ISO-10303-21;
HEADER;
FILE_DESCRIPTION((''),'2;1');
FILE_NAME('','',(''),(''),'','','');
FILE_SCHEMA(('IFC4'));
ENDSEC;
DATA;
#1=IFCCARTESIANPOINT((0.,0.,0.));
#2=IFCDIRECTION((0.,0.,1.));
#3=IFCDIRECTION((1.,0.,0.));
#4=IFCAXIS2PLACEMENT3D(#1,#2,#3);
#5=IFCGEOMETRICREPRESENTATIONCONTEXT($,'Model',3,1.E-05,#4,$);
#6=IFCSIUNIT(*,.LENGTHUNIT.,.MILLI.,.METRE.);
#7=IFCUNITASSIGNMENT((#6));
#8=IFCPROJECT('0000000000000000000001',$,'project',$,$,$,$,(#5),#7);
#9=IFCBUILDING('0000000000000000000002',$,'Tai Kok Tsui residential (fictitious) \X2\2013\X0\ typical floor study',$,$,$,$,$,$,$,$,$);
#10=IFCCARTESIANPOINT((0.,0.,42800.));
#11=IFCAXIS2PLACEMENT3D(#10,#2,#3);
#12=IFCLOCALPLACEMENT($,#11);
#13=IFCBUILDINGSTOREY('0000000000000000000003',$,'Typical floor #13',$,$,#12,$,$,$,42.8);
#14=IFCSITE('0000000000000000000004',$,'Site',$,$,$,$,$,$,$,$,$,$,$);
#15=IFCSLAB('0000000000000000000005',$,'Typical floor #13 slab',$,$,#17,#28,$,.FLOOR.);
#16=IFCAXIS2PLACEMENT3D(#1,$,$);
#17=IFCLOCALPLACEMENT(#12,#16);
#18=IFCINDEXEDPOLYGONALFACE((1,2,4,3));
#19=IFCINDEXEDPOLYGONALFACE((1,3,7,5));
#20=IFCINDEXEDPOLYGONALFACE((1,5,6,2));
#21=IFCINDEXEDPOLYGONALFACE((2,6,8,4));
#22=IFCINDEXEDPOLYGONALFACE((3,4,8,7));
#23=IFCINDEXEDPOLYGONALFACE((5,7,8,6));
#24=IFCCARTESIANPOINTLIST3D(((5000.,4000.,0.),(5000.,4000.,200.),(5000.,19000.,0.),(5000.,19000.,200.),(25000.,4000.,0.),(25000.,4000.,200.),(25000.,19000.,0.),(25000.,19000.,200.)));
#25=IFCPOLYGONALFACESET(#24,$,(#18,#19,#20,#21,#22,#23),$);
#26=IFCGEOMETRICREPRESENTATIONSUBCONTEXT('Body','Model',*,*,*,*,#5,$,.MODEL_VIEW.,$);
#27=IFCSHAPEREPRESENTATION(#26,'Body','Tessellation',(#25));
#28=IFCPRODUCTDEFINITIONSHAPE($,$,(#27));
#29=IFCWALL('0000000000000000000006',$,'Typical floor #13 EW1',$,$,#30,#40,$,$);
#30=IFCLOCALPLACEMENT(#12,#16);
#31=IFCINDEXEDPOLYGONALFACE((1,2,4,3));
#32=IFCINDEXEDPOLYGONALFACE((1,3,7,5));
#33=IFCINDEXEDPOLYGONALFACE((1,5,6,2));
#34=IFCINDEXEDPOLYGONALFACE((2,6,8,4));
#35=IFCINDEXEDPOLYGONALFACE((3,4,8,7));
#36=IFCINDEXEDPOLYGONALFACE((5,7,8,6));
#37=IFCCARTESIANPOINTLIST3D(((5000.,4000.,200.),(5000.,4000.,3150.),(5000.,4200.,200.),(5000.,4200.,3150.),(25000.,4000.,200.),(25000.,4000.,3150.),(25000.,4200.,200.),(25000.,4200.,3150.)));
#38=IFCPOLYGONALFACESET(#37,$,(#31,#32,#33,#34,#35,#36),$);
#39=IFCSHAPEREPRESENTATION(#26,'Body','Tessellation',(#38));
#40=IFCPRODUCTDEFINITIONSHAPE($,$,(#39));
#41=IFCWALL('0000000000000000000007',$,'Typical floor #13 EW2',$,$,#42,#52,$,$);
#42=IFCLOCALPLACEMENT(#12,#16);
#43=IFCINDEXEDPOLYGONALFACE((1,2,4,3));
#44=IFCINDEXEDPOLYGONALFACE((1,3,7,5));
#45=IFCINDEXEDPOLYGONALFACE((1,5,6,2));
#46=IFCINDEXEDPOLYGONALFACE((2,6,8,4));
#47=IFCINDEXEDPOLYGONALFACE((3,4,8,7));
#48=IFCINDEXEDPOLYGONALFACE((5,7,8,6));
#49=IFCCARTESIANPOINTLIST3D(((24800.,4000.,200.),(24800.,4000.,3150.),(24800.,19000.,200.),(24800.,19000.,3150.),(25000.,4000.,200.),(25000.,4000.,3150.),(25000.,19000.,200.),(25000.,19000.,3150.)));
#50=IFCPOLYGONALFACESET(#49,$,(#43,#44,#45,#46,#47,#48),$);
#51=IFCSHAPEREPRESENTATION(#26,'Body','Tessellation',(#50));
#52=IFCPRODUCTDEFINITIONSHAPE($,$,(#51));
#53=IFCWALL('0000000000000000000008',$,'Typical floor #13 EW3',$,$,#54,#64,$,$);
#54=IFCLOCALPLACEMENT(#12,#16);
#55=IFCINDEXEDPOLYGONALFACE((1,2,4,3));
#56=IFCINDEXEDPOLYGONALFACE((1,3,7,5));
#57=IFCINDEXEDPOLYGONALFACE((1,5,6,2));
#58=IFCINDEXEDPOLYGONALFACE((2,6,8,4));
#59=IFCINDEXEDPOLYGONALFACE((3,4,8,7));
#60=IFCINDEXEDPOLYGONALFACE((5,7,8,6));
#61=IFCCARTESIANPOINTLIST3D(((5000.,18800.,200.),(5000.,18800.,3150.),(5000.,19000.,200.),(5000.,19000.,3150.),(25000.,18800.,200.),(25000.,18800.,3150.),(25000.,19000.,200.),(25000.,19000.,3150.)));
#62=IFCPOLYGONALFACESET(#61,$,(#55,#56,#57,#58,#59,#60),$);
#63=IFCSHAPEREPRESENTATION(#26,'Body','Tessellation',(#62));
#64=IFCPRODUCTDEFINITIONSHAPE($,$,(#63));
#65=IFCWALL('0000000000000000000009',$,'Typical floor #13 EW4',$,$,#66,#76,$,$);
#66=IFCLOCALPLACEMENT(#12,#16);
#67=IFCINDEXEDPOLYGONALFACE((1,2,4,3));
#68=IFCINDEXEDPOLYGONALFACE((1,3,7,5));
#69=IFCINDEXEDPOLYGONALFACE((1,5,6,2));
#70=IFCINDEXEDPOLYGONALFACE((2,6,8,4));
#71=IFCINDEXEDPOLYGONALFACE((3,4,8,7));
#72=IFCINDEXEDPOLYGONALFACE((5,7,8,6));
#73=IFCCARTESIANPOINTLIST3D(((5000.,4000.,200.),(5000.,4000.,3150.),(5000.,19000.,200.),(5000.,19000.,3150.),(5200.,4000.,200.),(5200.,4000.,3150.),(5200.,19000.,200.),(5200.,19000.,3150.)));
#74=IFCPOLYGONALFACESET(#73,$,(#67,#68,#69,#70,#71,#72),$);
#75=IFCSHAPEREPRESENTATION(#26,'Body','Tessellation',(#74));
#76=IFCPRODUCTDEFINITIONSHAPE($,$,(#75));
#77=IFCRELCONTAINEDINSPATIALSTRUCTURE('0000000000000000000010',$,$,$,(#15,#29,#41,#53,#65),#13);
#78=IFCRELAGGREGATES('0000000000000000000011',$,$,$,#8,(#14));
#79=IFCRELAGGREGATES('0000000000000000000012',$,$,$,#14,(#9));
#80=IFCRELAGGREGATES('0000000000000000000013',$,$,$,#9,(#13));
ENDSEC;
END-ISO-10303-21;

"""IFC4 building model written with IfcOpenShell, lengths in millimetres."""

from ifc_helpers import new_model, si_unit, frame, origin_with_axes, place, context, subcontext, project, spatial, indexed_curve, outline, extrude, element, save


model = new_model("IFC4")

# Units and contexts
model_context = context("Model", 3, precision=1e-05, world=origin_with_axes())
body_context = subcontext(model_context, "Body", "Model", "MODEL_VIEW")
ifc_project = project(units=[si_unit("LENGTHUNIT", "METRE", prefix="MILLI")], contexts=[model_context])

# Site, building, storey
site = spatial("IfcSite", under=ifc_project, Name="Site")
building = spatial("IfcBuilding", under=site, Name="Tai Kok Tsui residential (fictitious) – typical floor study")
storey_placement = place(None, frame((0.0, 0.0, 42800.0), z_axis=(0.0, 0.0, 1.0), x_axis=(1.0, 0.0, 0.0)))
storey = spatial("IfcBuildingStorey", under=building, at=storey_placement, Name="Typical floor #13", Elevation=42.8)

# Slab
slab_placement = place(storey_placement, origin_with_axes())
element("IfcSlab", 1, at=slab_placement, inside=storey, Name="Typical floor #13 slab", PredefinedType="FLOOR", context=body_context, shape_type="SweptSolid", body=[
    extrude(outline(indexed_curve([(5000.0, 4000.0), (25000.0, 4000.0), (25000.0, 19000.0), (5000.0, 19000.0)])), None, (0.0, 0.0, 1.0), 200.0),
])

# Walls
wall_1_placement = place(storey_placement, frame((5000.0, 4000.0, 200.0), z_axis=(0.0, 0.0, 1.0), x_axis=(1.0, 0.0, 0.0)))
element("IfcWall", 2, at=wall_1_placement, inside=storey, Name="Typical floor #13 EW1", context=body_context, shape_type="SweptSolid", body=[
    extrude(outline(indexed_curve([(0.0, 0.0), (0.0, 200.0), (20000.0, 200.0), (20000.0, 0.0), (0.0, 0.0)], self_intersect=False)), origin_with_axes(), (0.0, 0.0, 1.0), 2950.0),
])
wall_2_placement = place(storey_placement, frame((25000.0, 4000.0, 200.0), z_axis=(0.0, 0.0, 1.0), x_axis=(0.0, 1.0, 0.0)))
element("IfcWall", 3, at=wall_2_placement, inside=storey, Name="Typical floor #13 EW2", context=body_context, shape_type="SweptSolid", body=[
    extrude(outline(indexed_curve([(0.0, 0.0), (0.0, 200.0), (15000.0, 200.0), (15000.0, 0.0), (0.0, 0.0)], self_intersect=False)), origin_with_axes(), (0.0, 0.0, 1.0), 2950.0),
])
wall_3_placement = place(storey_placement, frame((25000.0, 19000.0, 200.0), z_axis=(0.0, 0.0, 1.0), x_axis=(-1.0, 0.0, 0.0)))
element("IfcWall", 4, at=wall_3_placement, inside=storey, Name="Typical floor #13 EW3", context=body_context, shape_type="SweptSolid", body=[
    extrude(outline(indexed_curve([(0.0, 0.0), (0.0, 200.0), (20000.0, 200.0), (20000.0, 0.0), (0.0, 0.0)], self_intersect=False)), origin_with_axes(), (0.0, 0.0, 1.0), 2950.0),
])
wall_4_placement = place(storey_placement, frame((5000.0, 19000.0, 200.0), z_axis=(0.0, 0.0, 1.0), x_axis=(0.0, -1.0, 0.0)))
element("IfcWall", 5, at=wall_4_placement, inside=storey, Name="Typical floor #13 EW4", context=body_context, shape_type="SweptSolid", body=[
    extrude(outline(indexed_curve([(0.0, 0.0), (0.0, 200.0), (15000.0, 200.0), (15000.0, 0.0), (0.0, 0.0)], self_intersect=False)), origin_with_axes(), (0.0, 0.0, 1.0), 2950.0),
])

save(model, "model.ifc")
